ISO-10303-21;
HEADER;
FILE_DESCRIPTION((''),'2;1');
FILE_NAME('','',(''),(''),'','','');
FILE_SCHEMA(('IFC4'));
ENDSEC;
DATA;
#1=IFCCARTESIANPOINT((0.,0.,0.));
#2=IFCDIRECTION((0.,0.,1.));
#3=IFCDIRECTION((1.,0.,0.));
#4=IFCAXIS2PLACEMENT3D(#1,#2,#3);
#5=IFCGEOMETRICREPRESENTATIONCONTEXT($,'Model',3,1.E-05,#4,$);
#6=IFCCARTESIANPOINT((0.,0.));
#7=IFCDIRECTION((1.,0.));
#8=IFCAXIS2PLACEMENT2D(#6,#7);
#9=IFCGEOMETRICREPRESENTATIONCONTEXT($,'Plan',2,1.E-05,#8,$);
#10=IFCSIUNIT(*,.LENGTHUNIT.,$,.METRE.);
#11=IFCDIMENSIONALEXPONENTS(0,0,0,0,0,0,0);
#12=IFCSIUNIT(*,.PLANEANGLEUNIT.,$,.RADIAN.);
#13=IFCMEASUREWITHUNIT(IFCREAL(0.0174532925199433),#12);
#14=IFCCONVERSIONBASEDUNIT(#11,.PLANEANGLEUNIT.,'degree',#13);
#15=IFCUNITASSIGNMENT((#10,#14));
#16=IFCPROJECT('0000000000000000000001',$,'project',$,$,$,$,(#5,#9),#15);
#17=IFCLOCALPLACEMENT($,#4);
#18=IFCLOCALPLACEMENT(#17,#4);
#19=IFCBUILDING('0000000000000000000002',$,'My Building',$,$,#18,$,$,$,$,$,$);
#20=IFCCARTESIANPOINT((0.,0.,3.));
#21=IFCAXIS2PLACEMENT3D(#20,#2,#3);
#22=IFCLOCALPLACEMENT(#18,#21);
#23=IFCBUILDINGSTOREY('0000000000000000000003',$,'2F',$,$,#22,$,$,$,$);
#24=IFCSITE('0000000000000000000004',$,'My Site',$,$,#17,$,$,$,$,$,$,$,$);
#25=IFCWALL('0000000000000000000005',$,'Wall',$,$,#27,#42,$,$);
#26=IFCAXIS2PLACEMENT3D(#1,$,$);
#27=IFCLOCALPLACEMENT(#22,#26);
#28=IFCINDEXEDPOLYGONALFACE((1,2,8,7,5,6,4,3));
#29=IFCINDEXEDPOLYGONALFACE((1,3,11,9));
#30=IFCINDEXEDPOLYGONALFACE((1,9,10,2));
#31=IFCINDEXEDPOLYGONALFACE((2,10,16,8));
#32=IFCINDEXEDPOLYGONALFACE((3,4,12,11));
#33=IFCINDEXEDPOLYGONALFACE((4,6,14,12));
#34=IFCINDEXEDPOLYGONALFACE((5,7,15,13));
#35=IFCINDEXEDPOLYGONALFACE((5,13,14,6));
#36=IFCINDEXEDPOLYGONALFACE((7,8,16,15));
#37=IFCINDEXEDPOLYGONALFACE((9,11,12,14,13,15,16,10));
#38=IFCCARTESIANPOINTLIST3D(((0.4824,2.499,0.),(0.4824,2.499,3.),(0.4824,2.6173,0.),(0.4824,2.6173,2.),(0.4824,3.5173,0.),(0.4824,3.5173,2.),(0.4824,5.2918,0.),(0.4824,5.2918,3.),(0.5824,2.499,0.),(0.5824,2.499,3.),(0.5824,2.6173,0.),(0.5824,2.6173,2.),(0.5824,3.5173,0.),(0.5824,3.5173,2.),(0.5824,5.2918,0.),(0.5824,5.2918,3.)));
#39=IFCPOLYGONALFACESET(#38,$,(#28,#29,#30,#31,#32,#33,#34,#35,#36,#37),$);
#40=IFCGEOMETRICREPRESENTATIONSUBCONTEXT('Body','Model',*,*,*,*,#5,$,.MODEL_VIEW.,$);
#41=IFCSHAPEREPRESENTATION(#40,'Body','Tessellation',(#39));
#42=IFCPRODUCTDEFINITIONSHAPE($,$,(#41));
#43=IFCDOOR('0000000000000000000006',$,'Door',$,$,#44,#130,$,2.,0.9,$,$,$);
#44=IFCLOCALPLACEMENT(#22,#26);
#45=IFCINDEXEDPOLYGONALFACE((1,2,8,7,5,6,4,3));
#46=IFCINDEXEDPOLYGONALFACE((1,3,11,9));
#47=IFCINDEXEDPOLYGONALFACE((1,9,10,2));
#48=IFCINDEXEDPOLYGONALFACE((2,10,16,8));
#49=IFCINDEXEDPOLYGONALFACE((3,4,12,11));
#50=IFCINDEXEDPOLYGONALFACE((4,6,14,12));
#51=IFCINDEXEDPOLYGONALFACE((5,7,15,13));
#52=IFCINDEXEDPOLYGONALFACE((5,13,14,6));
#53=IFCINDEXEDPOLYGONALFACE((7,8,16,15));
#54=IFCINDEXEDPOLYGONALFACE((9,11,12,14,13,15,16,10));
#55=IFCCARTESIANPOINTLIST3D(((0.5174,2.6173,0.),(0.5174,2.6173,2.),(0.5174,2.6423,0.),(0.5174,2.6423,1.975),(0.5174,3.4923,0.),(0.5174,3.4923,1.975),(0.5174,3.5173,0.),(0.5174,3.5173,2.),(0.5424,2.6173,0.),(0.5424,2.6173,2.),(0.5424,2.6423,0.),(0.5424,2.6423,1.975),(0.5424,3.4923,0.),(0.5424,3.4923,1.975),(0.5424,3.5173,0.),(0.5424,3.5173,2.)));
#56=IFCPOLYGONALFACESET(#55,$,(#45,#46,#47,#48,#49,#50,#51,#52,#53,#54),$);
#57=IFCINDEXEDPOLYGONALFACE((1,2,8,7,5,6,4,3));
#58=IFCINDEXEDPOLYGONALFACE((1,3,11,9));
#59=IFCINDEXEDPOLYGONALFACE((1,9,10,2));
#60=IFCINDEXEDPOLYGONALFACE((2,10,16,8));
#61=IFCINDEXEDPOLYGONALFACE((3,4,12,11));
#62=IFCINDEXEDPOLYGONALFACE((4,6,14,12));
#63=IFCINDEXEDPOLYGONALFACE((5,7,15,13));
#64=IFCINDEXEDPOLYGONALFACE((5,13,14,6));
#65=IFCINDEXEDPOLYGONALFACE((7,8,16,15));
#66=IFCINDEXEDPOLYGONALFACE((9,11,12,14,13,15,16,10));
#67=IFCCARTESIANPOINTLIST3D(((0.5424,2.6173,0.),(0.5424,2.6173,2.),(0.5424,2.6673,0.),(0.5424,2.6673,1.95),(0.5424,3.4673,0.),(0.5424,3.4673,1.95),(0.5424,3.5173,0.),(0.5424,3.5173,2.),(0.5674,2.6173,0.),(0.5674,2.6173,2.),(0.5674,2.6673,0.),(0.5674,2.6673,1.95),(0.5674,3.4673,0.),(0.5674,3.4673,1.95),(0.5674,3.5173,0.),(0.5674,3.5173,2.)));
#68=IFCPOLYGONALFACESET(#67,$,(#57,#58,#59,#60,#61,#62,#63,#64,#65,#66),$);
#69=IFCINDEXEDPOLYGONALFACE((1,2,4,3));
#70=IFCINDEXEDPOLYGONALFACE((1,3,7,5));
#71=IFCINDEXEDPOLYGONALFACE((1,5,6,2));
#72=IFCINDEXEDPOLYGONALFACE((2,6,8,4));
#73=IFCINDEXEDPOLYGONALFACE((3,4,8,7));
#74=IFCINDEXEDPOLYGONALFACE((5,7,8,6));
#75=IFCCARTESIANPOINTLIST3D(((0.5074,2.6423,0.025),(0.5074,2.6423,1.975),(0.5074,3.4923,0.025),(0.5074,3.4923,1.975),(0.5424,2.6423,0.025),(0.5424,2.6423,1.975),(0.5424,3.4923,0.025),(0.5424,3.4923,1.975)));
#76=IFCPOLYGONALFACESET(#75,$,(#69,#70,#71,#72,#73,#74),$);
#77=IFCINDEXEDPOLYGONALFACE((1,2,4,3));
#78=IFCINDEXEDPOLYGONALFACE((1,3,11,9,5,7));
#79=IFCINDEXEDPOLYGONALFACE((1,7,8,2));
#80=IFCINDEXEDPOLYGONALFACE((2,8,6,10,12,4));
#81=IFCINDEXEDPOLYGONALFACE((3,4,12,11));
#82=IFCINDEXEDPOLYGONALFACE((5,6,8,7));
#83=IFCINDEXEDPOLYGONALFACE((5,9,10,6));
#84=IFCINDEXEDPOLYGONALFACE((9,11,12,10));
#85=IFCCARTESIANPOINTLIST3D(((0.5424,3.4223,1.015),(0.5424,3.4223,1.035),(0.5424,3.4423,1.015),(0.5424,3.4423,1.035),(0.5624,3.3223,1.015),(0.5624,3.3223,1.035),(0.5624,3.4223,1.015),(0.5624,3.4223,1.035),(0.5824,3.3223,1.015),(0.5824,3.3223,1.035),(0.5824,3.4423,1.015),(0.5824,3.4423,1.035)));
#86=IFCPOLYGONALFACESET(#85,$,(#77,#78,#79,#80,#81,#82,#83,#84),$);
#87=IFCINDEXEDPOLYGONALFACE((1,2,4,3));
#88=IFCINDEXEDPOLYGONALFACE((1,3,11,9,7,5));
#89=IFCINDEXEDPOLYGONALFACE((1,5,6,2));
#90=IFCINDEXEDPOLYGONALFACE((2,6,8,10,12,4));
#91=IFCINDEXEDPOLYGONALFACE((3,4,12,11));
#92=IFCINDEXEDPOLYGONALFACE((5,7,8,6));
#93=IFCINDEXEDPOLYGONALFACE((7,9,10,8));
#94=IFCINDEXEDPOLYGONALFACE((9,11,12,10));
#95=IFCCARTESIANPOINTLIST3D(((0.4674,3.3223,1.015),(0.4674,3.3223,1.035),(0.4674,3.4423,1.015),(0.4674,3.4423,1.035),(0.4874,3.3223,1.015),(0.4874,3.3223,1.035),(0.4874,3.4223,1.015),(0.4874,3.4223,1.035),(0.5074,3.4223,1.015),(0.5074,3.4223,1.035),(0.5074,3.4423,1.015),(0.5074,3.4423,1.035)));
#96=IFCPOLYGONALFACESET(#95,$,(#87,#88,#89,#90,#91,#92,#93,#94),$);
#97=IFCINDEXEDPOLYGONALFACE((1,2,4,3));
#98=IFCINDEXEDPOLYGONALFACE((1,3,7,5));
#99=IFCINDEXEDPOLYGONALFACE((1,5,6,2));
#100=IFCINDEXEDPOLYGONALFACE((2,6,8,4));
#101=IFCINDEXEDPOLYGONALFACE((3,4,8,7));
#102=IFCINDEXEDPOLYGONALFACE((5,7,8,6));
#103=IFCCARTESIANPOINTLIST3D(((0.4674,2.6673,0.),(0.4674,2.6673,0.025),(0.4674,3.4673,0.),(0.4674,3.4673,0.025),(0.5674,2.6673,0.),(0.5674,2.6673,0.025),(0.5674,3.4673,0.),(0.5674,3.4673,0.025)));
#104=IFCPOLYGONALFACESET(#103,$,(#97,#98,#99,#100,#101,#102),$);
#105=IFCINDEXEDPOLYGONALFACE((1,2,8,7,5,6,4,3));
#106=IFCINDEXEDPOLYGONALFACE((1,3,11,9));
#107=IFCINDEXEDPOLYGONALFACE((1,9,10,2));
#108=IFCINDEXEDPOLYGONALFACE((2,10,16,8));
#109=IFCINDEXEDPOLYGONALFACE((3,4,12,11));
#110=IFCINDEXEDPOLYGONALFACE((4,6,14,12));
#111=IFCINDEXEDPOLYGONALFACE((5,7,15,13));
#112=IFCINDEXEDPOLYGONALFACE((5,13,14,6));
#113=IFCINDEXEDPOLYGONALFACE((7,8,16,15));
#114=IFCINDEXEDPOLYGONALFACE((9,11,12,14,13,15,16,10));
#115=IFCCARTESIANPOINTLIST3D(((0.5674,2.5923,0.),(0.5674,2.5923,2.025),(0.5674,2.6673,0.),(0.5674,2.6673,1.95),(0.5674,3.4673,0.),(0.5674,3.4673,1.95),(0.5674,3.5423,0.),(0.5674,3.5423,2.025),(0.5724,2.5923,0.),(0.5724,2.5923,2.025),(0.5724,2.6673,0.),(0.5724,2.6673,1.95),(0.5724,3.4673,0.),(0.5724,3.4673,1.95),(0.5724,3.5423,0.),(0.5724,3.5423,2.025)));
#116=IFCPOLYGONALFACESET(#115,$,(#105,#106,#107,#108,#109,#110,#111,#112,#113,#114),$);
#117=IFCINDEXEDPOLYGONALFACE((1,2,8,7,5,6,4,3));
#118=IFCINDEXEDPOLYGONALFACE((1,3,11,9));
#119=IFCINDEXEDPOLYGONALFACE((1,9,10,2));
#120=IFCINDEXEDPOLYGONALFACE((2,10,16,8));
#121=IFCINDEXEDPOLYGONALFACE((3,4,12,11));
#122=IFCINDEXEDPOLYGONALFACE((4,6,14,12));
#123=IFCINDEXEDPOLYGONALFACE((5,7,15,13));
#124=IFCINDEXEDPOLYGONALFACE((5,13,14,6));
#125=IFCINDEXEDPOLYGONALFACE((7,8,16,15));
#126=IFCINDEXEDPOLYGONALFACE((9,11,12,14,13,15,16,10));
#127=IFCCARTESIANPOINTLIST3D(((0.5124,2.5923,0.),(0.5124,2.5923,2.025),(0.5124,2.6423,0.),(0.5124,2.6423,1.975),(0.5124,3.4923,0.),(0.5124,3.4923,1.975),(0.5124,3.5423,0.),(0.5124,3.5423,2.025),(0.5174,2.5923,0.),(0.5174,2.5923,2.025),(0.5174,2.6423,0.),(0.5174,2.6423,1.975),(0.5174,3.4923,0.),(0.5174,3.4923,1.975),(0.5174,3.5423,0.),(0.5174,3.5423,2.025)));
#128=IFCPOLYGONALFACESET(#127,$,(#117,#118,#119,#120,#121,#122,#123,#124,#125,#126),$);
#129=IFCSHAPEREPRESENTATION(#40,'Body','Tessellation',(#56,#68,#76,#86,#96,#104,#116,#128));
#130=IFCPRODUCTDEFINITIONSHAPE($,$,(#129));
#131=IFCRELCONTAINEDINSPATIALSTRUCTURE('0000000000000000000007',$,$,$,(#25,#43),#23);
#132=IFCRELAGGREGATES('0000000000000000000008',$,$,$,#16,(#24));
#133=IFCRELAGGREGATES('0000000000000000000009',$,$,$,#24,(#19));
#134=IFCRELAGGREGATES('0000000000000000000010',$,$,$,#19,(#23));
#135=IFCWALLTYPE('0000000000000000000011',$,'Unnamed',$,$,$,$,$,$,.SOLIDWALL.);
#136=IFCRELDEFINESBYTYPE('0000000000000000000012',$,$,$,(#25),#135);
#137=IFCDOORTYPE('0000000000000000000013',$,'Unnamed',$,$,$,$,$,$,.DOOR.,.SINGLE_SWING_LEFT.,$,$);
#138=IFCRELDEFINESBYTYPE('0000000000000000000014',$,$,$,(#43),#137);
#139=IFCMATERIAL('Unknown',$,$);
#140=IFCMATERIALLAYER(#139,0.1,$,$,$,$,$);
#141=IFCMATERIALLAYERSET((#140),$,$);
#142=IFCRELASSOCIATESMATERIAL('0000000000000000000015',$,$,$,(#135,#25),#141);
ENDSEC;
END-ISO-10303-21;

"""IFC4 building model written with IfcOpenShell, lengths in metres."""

from ifc_helpers import new_model, entity, si_unit, converted_unit, frame, origin_with_axes, origin_2d_with_axis, place, context, subcontext, project, spatial, line, indexed_curve, outline, extrude, shape, source, transform, mapped, material, layer, layer_set, layer_usage, type_object, type_shapes, element, fill, save


model = new_model("IFC4")

# Units and contexts
model_context = context("Model", 3, precision=1e-05, world=origin_with_axes())
plan_context = context("Plan", 2, precision=1e-05, world=origin_2d_with_axis())
body_context_1 = subcontext(model_context, "Body", "Model", "MODEL_VIEW")
body_context_2 = subcontext(plan_context, "Body", "Plan", "PLAN_VIEW")
ifc_project = project(units=[si_unit("LENGTHUNIT", "METRE"), converted_unit("PLANEANGLEUNIT", "degree", entity("IfcReal", 0.0174532925199433), si_unit("PLANEANGLEUNIT", "RADIAN"), dimensions=[0, 0, 0, 0, 0, 0, 0])], contexts=[model_context, plan_context])

# Site, building, storey
site_placement = place(None, origin_with_axes())
site = spatial("IfcSite", under=ifc_project, at=site_placement, Name="My Site")
building_placement = place(site_placement, origin_with_axes())
building = spatial("IfcBuilding", under=site, at=building_placement, Name="My Building")
storey_placement = place(building_placement, frame((0.0, 0.0, 3.0), z_axis=(0.0, 0.0, 1.0), x_axis=(1.0, 0.0, 0.0)))
storey = spatial("IfcBuildingStorey", under=building, at=storey_placement, Name="2F")

# Shared definitions
ifc_material = material(Name="Unknown")

# Shared definitions
ifc_layer_1 = layer(ifc_material, 0.1)
ifc_layer_set_1 = layer_set([ifc_layer_1])
wall_type = type_object("IfcWallType", Name="Unnamed", PredefinedType="SOLIDWALL", material=ifc_layer_set_1)

# Wall, opening, door
shared_shape_1 = source(origin_with_axes(), body_context_1, "Body", "SweptSolid", [
    extrude(outline(indexed_curve([(0.0, 0.0), (0.9, 0.0), (0.9, 2.0), (0.0, 2.0)], segments=[line(1, 2, 3, 4, 1)])), frame((0.0, -0.6, 0.0), z_axis=(0.0, -1.0, 0.0), x_axis=(1.0, 0.0, 0.0)), (0.0, 0.0, -1.0), 1.2),
])
door_type_1 = type_object("IfcDoorType", Name="Unnamed", OperationType="SINGLE_SWING_LEFT", PredefinedType="DOOR")
shared_shape_2 = source(origin_with_axes(), body_context_1, "Body", "SweptSolid", [
    extrude(outline(indexed_curve([(0.0, 0.0), (0.0, 2.0), (0.9, 2.0), (0.9, 0.0), (0.875, 0.0), (0.875, 1.975), (0.025, 1.975), (0.025, 0.0)], segments=[line(1, 2, 3, 4, 5, 6, 7, 8, 1)])), frame((0.0, 0.025, 0.0), z_axis=(0.0, -1.0, 0.0), x_axis=(1.0, 0.0, 0.0)), (0.0, 0.0, -1.0), 0.025),
    extrude(outline(indexed_curve([(0.0, 0.0), (0.0, 2.0), (0.9, 2.0), (0.9, 0.0), (0.85, 0.0), (0.85, 1.95), (0.05, 1.95), (0.05, 0.0)], segments=[line(1, 2, 3, 4, 5, 6, 7, 8, 1)])), frame((0.0, 0.0, 0.0), z_axis=(0.0, -1.0, 0.0), x_axis=(1.0, 0.0, 0.0)), (0.0, 0.0, -1.0), 0.025),
    extrude(outline(indexed_curve([(0.0, 0.0), (0.85, 0.0), (0.85, 0.035), (0.0, 0.035)], segments=[line(1, 2, 3, 4, 1)])), frame((0.025, 0.025, 0.025), z_axis=(0.0, 0.0, 1.0), x_axis=(1.0, 0.0, 0.0)), (0.0, 0.0, 1.0), 1.95),
    extrude(outline(indexed_curve([(0.0, 0.0), (0.0, -0.04), (-0.12, -0.04), (-0.12, -0.02), (-0.02, -0.02), (-0.02, 0.0)], segments=[line(1, 2, 3, 4, 5, 6, 1)])), frame((0.825, 0.025, 1.015), z_axis=(0.0, 0.0, 1.0), x_axis=(1.0, 0.0, 0.0)), (0.0, 0.0, 1.0), 0.02),
    extrude(outline(indexed_curve([(0.0, 0.0), (0.0, 0.04), (-0.12, 0.04), (-0.12, 0.02), (-0.02, 0.02), (-0.02, 0.0)], segments=[line(1, 2, 3, 4, 5, 6, 1)])), frame((0.825, 0.06, 1.015), z_axis=(0.0, 0.0, 1.0), x_axis=(1.0, 0.0, 0.0)), (0.0, 0.0, 1.0), 0.02),
    extrude(outline(indexed_curve([(0.0, 0.0), (0.8, 0.0), (0.8, 0.1), (0.0, 0.1)], segments=[line(1, 2, 3, 4, 1)])), frame((0.05, 0.0, 0.0), z_axis=(0.0, 0.0, 1.0), x_axis=(1.0, 0.0, 0.0)), (0.0, 0.0, 1.0), 0.025),
    extrude(outline(indexed_curve([(0.0, 0.0), (0.0, 2.025), (0.95, 2.025), (0.95, 0.0), (0.875, 0.0), (0.875, 1.95), (0.075, 1.95), (0.075, 0.0)], segments=[line(1, 2, 3, 4, 5, 6, 7, 8, 1)])), frame((-0.025, -0.005, 0.0), z_axis=(0.0, -1.0, 0.0), x_axis=(1.0, 0.0, 0.0)), (0.0, 0.0, -1.0), 0.005),
    extrude(outline(indexed_curve([(0.0, 0.0), (0.0, 2.025), (0.95, 2.025), (0.95, 0.0), (0.9, 0.0), (0.9, 1.975), (0.05, 1.975), (0.05, 0.0)], segments=[line(1, 2, 3, 4, 5, 6, 7, 8, 1)])), frame((-0.025, 0.05, 0.0), z_axis=(0.0, -1.0, 0.0), x_axis=(1.0, 0.0, 0.0)), (0.0, 0.0, -1.0), 0.005),
])
shared_shape_3 = source(origin_with_axes(), body_context_2, "Body", "Curve2D", [
    entity("IfcIndexedPolyCurve", entity("IfcCartesianPointList2D", [[0.0, 0.0], [0.0, 0.05], [0.025, 0.05], [0.025, 0.025], [0.05, 0.025], [0.05, 0.0]]), [entity("IfcLineIndex", [1, 2, 3, 4, 5, 6, 1])]),
    entity("IfcIndexedPolyCurve", entity("IfcCartesianPointList2D", [[0.9, 0.0], [0.9, 0.05], [0.875, 0.05], [0.875, 0.025], [0.85, 0.025], [0.85, 0.0]]), [entity("IfcLineIndex", [1, 2, 3, 4, 5, 6, 1])]),
    entity("IfcTrimmedCurve", entity("IfcEllipse", entity("IfcAxis2Placement2D", entity("IfcCartesianPoint", [0.06, 0.05]), entity("IfcDirection", [1.0, 0.0])), 0.815, 0.85), [entity("IfcCartesianPoint", [0.875, 0.05])], [entity("IfcCartesianPoint", [0.06, 0.9])], True, "CARTESIAN"),
    entity("IfcIndexedPolyCurve", entity("IfcCartesianPointList2D", [[0.025, 0.05], [0.06, 0.05], [0.06, 0.9], [0.025, 0.9]]), [entity("IfcLineIndex", [1, 2, 3, 4, 1])]),
])
type_shapes(door_type_1, [shared_shape_2, shared_shape_3])
ifc_layer_usage_1 = layer_usage(ifc_layer_set_1, "AXIS2", "POSITIVE", 0.0)
wall_1_placement = place(storey_placement, frame((0.4824, 5.2918, 0.0), z_axis=(0.0, 0.0, 1.0), x_axis=(0.0, -1.0, 0.0)))
wall_1 = element("IfcWall", 1, at=wall_1_placement, inside=storey, type_object=wall_type, material=ifc_layer_usage_1, Name="Wall", context=body_context_1, shape_type="SweptSolid", body=[
    extrude(outline(indexed_curve([(0.0, 0.0), (0.0, 0.1), (2.7929, 0.1), (2.7929, 0.0)], segments=[line(1, 2, 3, 4, 1)])), origin_with_axes(), (0.0, 0.0, 1.0), 3.0),
])
opening_1_placement = place(wall_1_placement, frame((1.7746, 0.0, 0.0), z_axis=(0.0, 0.0, 1.0), x_axis=(1.0, 0.0, 0.0)))
opening_1 = element("IfcOpeningElement", 2, at=opening_1_placement, cuts=wall_1, PredefinedType="OPENING", context=body_context_1, shape_type="MappedRepresentation", body=[
    mapped(shared_shape_1, transform((0.0, 0.0, 0.0), x_axis=(1.0, 0.0, 0.0), y_axis=(0.0, 1.0, 0.0), z_axis=(0.0, 0.0, 1.0), scale=1.0)),
])
door_1_placement = place(opening_1_placement, frame((0.9, 0.085, 0.0), z_axis=(0.0, 0.0, 1.0), x_axis=(-1.0, 0.0, 0.0)))
door_1 = element("IfcDoor", 3, at=door_1_placement, inside=storey, type_object=door_type_1, Name="Door", OverallHeight=2.0, OverallWidth=0.9, shapes=[
    shape(body_context_1, "Body", "MappedRepresentation", [mapped(shared_shape_2, transform((0.0, 0.0, 0.0), x_axis=(1.0, 0.0, 0.0), y_axis=(0.0, 1.0, 0.0), z_axis=(0.0, 0.0, 1.0), scale=1.0))]),
    shape(body_context_2, "Body", "MappedRepresentation", [mapped(shared_shape_3, transform((0.0, 0.0, 0.0), x_axis=(1.0, 0.0, 0.0), y_axis=(0.0, 1.0, 0.0), z_axis=(0.0, 0.0, 1.0), scale=1.0))]),
])
fill(opening_1, door_1)

save(model, "model.ifc")
